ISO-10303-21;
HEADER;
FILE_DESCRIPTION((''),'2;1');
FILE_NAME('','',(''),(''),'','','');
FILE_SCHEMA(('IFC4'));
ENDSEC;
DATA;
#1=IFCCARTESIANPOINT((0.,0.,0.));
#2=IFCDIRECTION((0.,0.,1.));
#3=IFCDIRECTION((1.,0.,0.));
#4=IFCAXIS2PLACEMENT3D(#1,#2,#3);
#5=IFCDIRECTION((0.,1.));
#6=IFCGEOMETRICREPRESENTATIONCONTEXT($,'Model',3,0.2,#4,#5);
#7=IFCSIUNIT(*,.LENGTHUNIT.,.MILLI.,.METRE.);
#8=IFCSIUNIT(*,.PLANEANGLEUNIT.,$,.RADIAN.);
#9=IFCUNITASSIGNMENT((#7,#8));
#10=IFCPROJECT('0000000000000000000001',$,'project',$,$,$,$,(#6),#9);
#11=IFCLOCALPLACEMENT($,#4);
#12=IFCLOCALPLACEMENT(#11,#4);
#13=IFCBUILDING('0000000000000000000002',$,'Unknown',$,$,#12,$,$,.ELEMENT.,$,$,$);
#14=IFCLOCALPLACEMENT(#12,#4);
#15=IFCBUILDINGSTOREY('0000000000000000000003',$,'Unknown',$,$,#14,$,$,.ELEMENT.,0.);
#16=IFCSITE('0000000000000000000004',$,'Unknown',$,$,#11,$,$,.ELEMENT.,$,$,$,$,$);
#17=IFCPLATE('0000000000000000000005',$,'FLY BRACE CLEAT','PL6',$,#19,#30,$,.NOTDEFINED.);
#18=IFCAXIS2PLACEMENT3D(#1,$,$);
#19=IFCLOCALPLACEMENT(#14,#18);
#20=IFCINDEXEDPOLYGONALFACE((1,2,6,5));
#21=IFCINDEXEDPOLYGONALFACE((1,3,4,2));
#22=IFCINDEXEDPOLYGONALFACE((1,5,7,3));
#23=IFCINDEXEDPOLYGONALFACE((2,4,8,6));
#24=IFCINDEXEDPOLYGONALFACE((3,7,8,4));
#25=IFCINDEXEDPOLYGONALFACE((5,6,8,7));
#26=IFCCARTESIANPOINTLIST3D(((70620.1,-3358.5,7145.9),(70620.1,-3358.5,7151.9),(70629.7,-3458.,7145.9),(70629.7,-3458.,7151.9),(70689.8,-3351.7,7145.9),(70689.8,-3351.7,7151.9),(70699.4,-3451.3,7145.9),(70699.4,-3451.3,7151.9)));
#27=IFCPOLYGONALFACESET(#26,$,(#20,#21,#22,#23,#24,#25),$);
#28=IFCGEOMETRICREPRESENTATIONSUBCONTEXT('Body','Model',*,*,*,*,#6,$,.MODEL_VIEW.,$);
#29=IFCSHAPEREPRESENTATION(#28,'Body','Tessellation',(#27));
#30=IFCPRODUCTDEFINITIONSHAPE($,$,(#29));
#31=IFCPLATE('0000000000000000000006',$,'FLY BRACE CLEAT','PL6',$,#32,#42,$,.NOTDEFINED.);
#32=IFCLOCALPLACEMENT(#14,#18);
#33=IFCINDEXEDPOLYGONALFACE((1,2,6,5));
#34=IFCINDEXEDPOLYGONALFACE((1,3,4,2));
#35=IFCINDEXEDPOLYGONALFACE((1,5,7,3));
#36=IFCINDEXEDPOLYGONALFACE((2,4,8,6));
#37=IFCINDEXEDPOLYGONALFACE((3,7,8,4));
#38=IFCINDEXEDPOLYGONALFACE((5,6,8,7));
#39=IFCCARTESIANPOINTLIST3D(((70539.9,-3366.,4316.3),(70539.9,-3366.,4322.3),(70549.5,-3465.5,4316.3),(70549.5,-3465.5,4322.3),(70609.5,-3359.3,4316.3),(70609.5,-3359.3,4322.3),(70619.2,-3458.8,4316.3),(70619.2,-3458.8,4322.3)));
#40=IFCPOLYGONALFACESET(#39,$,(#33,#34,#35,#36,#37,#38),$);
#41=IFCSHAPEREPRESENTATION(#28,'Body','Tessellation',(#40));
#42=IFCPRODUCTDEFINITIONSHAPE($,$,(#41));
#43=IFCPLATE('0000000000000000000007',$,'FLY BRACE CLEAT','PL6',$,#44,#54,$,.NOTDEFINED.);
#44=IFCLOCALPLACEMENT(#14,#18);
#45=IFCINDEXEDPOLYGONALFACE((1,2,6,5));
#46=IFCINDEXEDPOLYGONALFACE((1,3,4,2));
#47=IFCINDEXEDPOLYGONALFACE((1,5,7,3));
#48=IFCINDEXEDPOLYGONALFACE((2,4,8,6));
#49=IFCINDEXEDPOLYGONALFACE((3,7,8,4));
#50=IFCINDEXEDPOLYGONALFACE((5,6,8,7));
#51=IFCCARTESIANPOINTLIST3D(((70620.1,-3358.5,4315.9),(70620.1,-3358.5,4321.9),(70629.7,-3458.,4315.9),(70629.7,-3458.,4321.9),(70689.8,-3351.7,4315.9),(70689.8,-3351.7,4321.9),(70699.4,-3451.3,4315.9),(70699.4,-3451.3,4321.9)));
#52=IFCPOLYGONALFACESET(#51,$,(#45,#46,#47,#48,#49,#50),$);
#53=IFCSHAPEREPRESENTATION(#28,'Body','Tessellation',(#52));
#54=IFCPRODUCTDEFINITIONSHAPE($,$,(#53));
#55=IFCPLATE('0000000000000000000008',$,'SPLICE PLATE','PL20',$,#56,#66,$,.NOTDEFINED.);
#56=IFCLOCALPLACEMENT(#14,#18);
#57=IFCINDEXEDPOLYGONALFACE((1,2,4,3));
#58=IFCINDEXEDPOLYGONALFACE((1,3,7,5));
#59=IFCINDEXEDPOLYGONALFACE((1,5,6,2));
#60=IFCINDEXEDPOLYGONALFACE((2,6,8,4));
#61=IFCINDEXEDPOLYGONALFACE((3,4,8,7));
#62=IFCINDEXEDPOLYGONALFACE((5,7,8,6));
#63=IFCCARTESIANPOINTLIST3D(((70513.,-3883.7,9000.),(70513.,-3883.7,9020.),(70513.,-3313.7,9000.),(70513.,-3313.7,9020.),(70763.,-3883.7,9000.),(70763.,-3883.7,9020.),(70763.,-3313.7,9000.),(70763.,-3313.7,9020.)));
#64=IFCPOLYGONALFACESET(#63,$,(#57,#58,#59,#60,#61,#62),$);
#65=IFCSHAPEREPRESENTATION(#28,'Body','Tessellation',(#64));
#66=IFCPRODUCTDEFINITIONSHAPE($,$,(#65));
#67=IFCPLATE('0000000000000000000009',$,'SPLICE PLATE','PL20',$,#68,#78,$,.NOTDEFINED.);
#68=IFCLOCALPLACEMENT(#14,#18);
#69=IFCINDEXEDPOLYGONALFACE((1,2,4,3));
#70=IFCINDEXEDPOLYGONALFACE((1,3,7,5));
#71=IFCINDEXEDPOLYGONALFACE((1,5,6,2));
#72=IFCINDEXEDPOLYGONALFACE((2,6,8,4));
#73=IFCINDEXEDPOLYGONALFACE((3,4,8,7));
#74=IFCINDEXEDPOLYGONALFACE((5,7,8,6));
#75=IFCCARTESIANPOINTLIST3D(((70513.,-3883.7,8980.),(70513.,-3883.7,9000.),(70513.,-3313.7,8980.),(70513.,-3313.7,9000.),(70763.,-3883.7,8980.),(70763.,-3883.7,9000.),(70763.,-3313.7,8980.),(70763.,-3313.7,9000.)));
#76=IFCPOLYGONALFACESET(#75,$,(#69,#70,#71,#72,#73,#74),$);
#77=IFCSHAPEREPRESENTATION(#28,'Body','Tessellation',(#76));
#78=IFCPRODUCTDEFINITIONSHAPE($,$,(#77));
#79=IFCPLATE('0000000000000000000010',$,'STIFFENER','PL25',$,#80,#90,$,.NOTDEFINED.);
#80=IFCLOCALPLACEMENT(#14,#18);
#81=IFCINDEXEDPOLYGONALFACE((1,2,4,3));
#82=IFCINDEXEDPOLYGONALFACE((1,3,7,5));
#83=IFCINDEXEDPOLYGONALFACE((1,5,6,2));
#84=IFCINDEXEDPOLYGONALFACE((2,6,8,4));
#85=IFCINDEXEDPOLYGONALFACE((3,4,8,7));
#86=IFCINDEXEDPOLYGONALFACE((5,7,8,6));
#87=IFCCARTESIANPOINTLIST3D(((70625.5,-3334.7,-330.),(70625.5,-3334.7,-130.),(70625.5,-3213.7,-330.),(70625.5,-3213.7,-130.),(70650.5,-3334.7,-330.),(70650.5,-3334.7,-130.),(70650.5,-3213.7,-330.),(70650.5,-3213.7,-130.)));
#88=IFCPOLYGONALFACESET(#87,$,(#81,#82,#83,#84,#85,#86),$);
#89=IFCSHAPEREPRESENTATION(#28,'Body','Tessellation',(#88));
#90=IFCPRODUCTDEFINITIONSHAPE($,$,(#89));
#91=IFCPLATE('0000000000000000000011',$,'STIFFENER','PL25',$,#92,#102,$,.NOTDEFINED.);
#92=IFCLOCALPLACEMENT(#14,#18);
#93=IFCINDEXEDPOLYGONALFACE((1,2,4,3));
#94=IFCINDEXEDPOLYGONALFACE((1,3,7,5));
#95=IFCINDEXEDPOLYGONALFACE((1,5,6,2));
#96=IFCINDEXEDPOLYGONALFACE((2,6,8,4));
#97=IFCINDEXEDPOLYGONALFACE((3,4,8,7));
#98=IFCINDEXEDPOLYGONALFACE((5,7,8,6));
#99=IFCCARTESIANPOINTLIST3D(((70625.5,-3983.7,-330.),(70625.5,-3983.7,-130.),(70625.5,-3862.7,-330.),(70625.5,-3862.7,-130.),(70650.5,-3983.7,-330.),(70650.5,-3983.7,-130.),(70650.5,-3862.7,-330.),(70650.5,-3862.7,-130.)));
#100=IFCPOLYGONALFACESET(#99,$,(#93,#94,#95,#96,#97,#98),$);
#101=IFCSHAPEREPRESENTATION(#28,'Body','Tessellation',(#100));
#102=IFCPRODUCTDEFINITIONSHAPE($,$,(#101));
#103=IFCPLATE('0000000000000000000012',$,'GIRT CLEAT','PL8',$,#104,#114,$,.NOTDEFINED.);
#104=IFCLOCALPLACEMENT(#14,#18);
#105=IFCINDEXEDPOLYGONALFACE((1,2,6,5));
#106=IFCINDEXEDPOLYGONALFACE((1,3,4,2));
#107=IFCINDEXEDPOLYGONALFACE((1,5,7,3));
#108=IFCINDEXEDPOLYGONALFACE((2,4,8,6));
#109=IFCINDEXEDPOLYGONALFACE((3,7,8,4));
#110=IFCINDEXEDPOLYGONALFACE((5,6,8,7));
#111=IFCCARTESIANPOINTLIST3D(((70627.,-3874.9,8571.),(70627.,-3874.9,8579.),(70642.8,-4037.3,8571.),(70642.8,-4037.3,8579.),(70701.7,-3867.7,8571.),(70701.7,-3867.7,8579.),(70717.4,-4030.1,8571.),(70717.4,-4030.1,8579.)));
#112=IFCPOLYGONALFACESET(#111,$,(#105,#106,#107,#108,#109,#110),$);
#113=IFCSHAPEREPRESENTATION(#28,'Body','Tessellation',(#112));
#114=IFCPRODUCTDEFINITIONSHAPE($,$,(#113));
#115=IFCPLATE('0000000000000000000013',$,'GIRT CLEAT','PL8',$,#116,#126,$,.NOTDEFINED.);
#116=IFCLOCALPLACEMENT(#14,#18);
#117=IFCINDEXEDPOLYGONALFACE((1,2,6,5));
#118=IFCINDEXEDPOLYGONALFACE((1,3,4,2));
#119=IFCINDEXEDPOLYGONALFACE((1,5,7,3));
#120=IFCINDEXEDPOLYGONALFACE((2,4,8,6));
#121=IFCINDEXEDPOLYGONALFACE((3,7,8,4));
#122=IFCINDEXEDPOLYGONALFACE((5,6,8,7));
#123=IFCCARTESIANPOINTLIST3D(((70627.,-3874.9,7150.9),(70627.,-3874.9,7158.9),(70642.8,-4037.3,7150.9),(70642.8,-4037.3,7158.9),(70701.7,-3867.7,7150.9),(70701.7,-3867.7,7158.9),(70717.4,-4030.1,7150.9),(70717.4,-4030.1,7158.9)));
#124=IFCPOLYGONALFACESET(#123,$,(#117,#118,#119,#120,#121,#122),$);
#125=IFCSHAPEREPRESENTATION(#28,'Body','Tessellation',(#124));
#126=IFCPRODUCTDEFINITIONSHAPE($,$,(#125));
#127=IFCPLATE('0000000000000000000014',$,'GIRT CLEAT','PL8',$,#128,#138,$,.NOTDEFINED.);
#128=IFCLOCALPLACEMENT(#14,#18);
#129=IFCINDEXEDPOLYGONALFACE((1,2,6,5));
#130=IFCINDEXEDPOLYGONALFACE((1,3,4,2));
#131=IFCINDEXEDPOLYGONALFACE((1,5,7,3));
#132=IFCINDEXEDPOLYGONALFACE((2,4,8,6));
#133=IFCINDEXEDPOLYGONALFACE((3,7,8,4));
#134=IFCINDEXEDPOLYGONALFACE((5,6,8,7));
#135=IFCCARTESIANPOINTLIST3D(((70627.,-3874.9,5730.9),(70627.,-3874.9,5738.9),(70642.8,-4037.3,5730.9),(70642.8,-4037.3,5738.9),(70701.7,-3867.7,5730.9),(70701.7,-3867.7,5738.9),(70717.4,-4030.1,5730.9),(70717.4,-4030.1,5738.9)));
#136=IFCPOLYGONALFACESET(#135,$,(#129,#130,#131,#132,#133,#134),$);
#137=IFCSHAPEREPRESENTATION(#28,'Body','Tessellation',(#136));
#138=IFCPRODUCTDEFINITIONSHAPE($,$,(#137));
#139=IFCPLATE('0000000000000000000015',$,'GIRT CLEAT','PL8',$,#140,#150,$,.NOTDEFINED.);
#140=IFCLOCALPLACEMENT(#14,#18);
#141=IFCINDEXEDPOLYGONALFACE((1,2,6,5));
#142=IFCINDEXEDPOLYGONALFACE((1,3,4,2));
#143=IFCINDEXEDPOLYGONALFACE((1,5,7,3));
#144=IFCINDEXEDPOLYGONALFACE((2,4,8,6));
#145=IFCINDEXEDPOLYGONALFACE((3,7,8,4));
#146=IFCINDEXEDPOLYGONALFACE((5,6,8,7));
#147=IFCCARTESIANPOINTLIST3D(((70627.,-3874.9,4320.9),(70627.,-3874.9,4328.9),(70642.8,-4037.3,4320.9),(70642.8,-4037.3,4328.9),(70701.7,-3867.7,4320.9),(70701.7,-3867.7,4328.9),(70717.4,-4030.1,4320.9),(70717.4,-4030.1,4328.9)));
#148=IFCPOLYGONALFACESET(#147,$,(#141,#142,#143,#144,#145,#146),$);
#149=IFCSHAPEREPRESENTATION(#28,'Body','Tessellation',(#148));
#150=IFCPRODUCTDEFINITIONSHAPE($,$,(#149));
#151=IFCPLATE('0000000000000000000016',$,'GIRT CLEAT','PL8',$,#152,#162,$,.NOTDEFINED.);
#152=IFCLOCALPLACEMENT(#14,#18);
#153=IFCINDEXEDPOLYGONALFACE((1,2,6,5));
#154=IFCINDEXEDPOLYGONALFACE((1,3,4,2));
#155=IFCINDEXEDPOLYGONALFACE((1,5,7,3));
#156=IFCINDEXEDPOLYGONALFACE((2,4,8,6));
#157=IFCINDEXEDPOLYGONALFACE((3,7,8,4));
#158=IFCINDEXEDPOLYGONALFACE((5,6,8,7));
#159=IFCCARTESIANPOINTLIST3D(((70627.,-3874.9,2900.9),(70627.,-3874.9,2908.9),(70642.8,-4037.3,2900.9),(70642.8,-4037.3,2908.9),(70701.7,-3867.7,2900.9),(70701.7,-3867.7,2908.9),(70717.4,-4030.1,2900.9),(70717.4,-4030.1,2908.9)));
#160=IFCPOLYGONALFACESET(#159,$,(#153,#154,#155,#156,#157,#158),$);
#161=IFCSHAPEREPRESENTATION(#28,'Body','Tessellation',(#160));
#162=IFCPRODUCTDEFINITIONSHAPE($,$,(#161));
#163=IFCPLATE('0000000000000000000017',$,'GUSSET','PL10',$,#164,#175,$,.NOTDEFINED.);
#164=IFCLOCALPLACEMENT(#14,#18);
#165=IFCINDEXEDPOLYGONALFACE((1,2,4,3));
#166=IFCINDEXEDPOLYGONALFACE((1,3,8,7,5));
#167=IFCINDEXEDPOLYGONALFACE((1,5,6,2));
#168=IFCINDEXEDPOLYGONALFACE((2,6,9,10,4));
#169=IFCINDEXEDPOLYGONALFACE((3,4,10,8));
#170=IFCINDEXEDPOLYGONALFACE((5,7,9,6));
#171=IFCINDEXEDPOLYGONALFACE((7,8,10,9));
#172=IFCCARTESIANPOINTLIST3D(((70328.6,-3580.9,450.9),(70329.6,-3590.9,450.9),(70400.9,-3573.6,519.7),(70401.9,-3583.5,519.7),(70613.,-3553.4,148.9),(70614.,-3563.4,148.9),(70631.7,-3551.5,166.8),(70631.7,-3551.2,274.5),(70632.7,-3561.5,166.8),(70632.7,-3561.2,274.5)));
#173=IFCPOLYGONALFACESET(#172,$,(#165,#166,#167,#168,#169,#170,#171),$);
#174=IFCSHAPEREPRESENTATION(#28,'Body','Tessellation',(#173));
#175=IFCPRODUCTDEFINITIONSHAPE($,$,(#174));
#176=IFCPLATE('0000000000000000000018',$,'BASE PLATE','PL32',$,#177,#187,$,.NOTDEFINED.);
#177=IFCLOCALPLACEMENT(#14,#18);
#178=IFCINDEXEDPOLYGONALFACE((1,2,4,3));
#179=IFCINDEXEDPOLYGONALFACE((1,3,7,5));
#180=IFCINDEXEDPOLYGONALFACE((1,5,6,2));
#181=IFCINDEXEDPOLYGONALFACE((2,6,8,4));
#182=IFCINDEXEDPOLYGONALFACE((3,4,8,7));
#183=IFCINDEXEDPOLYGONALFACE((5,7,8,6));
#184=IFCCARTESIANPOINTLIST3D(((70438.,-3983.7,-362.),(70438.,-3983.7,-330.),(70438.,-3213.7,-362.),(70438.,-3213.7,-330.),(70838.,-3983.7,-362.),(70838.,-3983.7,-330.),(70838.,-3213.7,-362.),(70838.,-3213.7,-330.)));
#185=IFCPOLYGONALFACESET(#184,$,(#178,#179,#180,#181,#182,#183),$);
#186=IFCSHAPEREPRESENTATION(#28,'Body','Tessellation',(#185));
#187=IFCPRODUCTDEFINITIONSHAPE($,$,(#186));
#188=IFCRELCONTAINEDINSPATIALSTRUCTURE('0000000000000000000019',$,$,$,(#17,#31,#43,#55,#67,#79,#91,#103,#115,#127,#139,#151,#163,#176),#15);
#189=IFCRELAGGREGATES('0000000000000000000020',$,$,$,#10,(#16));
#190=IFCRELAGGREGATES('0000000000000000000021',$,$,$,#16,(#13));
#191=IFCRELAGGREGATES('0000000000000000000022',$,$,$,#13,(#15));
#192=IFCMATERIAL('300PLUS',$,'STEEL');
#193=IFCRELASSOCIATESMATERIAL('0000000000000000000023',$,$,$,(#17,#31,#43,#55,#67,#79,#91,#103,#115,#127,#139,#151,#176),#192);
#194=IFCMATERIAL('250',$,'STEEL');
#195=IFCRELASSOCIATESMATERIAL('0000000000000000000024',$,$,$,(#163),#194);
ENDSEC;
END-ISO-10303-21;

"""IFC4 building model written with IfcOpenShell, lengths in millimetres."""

from ifc_helpers import new_model, si_unit, direction, frame, origin_with_axes, place, context, subcontext, project, spatial, line, indexed_curve, outline, extrude, material, element, save


model = new_model("IFC4")

# Units and contexts
model_context = context("Model", 3, precision=0.2, world=origin_with_axes(), true_north=direction((0.0, 1.0)))
body_context = subcontext(model_context, "Body", "Model", "MODEL_VIEW")
ifc_project = project(units=[si_unit("LENGTHUNIT", "METRE", prefix="MILLI"), si_unit("PLANEANGLEUNIT", "RADIAN")], contexts=[model_context])

# Site, building, storey
site_placement = place(None, origin_with_axes())
site = spatial("IfcSite", under=ifc_project, at=site_placement, Name="Unknown", CompositionType="ELEMENT")
building_placement = place(site_placement, origin_with_axes())
building = spatial("IfcBuilding", under=site, at=building_placement, Name="Unknown", CompositionType="ELEMENT")
storey_placement = place(building_placement, origin_with_axes())
storey = spatial("IfcBuildingStorey", under=building, at=storey_placement, Name="Unknown", CompositionType="ELEMENT", Elevation=0.0)

# Shared definitions
ifc_material_1 = material(Name="300PLUS", Category="STEEL")

# Plates
plate_1_placement = place(storey_placement, frame((70629.7, -3458.0, 7148.9), z_axis=(0.0, 0.0, 1.0), x_axis=(0.995412, 0.095685, 0.0)))
element("IfcPlate", 1, at=plate_1_placement, inside=storey, material=ifc_material_1, Name="FLY BRACE CLEAT", Description="PL6", PredefinedType="NOTDEFINED", context=body_context, shape_type="SolidModel", body=[
    extrude(outline(indexed_curve([(0.0, 0.0), (70.0, 0.0), (70.0, 100.1), (0.0, 100.0)], segments=[line(1, 2, 3, 4, 1)])), frame((0.0, 0.0, 3.0), z_axis=(0.0, 0.0, 1.0), x_axis=(1.0, 0.0, 0.0)), (0.0, 0.0, -1.0), 6.0),
])
plate_2_placement = place(storey_placement, frame((70609.5, -3359.3, 4319.3), z_axis=(0.0, 0.0, 1.0), x_axis=(-0.995399, -0.095821, 0.0)))
element("IfcPlate", 2, at=plate_2_placement, inside=storey, material=ifc_material_1, Name="FLY BRACE CLEAT", Description="PL6", PredefinedType="NOTDEFINED", context=body_context, shape_type="SolidModel", body=[
    extrude(outline(indexed_curve([(0.0, 0.0), (69.9, 0.0), (69.9, 100.0), (-0.1, 100.0)], segments=[line(1, 2, 3, 4, 1)])), frame((0.0, 0.0, 3.0), z_axis=(0.0, 0.0, 1.0), x_axis=(1.0, 0.0, 0.0)), (0.0, 0.0, -1.0), 6.0),
])
plate_3_placement = place(storey_placement, frame((70629.7, -3458.0, 4318.9), z_axis=(0.0, 0.0, 1.0), x_axis=(0.995412, 0.095685, 0.0)))
element("IfcPlate", 3, at=plate_3_placement, inside=storey, material=ifc_material_1, Name="FLY BRACE CLEAT", Description="PL6", PredefinedType="NOTDEFINED", context=body_context, shape_type="SolidModel", body=[
    extrude(outline(indexed_curve([(0.0, 0.0), (70.0, 0.0), (70.0, 100.1), (0.0, 100.0)], segments=[line(1, 2, 3, 4, 1)])), frame((0.0, 0.0, 3.0), z_axis=(0.0, 0.0, 1.0), x_axis=(1.0, 0.0, 0.0)), (0.0, 0.0, -1.0), 6.0),
])
for number, where, z_axis, x_axis, name in (
    (4, (70763.0, -3883.7, 9010.0), (0.0, 0.0, 1.0), (0.0, 1.0, 0.0), "SPLICE PLATE"),
    (5, (70763.0, -3883.7, 8990.0), (0.0, 0.0, 1.0), (0.0, 1.0, 0.0), "SPLICE PLATE"),
):
    element("IfcPlate", number, at=place(storey_placement, frame(where, z_axis=z_axis, x_axis=x_axis)), inside=storey, material=ifc_material_1, Name=name, Description="PL20", PredefinedType="NOTDEFINED", context=body_context, shape_type="SolidModel", body=[
        extrude(outline(indexed_curve([(0.0, 0.0), (570.0, 0.0), (570.0, 250.0), (0.0, 250.0)], segments=[line(1, 2, 3, 4, 1)])), frame((0.0, 0.0, 10.0), z_axis=(0.0, 0.0, 1.0), x_axis=(1.0, 0.0, 0.0)), (0.0, 0.0, -1.0), 20.0),
    ])
for number, where, z_axis, x_axis, name in (
    (6, (70638.0, -3334.7, -330.0), (1.0, 0.0, 0.0), (0.0, 1.0, 0.0), "STIFFENER"),
    (7, (70638.0, -3862.7, -130.0), (1.0, 0.0, 0.0), (0.0, -1.0, 0.0), "STIFFENER"),
):
    element("IfcPlate", number, at=place(storey_placement, frame(where, z_axis=z_axis, x_axis=x_axis)), inside=storey, material=ifc_material_1, Name=name, Description="PL25", PredefinedType="NOTDEFINED", context=body_context, shape_type="SolidModel", body=[
        extrude(outline(indexed_curve([(0.0, 0.0), (121.0, 0.0), (121.0, 200.0), (0.0, 200.0)], segments=[line(1, 2, 3, 4, 1)])), frame((0.0, 0.0, 12.5), z_axis=(0.0, 0.0, 1.0), x_axis=(1.0, 0.0, 0.0)), (0.0, 0.0, -1.0), 25.0),
    ])
for number, where, z_axis, x_axis, name in (
    (8, (70642.8, -4037.3, 8575.0), (0.0, 0.0, 1.0), (0.995375, 0.096068, 0.0), "GIRT CLEAT"),
    (9, (70642.8, -4037.3, 7154.9), (0.0, 0.0, 1.0), (0.995375, 0.096068, 0.0), "GIRT CLEAT"),
    (10, (70642.8, -4037.3, 5734.9), (0.0, 0.0, 1.0), (0.995375, 0.096068, 0.0), "GIRT CLEAT"),
    (11, (70642.8, -4037.3, 4324.9), (0.0, 0.0, 1.0), (0.995375, 0.096068, 0.0), "GIRT CLEAT"),
    (12, (70642.8, -4037.3, 2904.9), (0.0, 0.0, 1.0), (0.995375, 0.096068, 0.0), "GIRT CLEAT"),
):
    element("IfcPlate", number, at=place(storey_placement, frame(where, z_axis=z_axis, x_axis=x_axis)), inside=storey, material=ifc_material_1, Name=name, Description="PL8", PredefinedType="NOTDEFINED", context=body_context, shape_type="SolidModel", body=[
        extrude(outline(indexed_curve([(0.0, 0.0), (74.9, 0.0), (74.9, 163.2), (-0.1, 163.2)], segments=[line(1, 2, 3, 4, 1)])), frame((0.0, 0.0, 4.0), z_axis=(0.0, 0.0, 1.0), x_axis=(1.0, 0.0, 0.0)), (0.0, 0.0, -1.0), 8.0),
    ])
ifc_material_2 = material(Name="250", Category="STEEL")
plate_4_placement = place(storey_placement, frame((70613.5, -3558.4, 148.9), z_axis=(0.098791, -0.995105, 0.00242), x_axis=(0.720452, 0.073201, 0.689631)))
element("IfcPlate", 13, at=plate_4_placement, inside=storey, material=ifc_material_2, Name="GUSSET", Description="PL10", PredefinedType="NOTDEFINED", context=body_context, shape_type="SolidModel", body=[
    extrude(outline(indexed_curve([(0.0, 0.0), (26.0, 0.0), (100.2, 78.0), (101.4, 415.5), (1.4, 415.7)], segments=[line(1, 2, 3, 4, 5, 1)])), frame((0.0, 0.0, 5.0), z_axis=(0.0, 0.0, 1.0), x_axis=(1.0, 0.0, 0.0)), (0.0, 0.0, -1.0), 10.0),
])
plate_5_placement = place(storey_placement, frame((70838.0, -3983.7, -346.0), z_axis=(0.0, 0.0, 1.0), x_axis=(0.0, 1.0, 0.0)))
element("IfcPlate", 14, at=plate_5_placement, inside=storey, material=ifc_material_1, Name="BASE PLATE", Description="PL32", PredefinedType="NOTDEFINED", context=body_context, shape_type="SolidModel", body=[
    extrude(outline(indexed_curve([(0.0, 0.0), (770.0, 0.0), (770.0, 400.0), (0.0, 400.0)], segments=[line(1, 2, 3, 4, 1)])), frame((0.0, 0.0, 16.0), z_axis=(0.0, 0.0, 1.0), x_axis=(1.0, 0.0, 0.0)), (0.0, 0.0, -1.0), 32.0),
])

save(model, "model.ifc")
